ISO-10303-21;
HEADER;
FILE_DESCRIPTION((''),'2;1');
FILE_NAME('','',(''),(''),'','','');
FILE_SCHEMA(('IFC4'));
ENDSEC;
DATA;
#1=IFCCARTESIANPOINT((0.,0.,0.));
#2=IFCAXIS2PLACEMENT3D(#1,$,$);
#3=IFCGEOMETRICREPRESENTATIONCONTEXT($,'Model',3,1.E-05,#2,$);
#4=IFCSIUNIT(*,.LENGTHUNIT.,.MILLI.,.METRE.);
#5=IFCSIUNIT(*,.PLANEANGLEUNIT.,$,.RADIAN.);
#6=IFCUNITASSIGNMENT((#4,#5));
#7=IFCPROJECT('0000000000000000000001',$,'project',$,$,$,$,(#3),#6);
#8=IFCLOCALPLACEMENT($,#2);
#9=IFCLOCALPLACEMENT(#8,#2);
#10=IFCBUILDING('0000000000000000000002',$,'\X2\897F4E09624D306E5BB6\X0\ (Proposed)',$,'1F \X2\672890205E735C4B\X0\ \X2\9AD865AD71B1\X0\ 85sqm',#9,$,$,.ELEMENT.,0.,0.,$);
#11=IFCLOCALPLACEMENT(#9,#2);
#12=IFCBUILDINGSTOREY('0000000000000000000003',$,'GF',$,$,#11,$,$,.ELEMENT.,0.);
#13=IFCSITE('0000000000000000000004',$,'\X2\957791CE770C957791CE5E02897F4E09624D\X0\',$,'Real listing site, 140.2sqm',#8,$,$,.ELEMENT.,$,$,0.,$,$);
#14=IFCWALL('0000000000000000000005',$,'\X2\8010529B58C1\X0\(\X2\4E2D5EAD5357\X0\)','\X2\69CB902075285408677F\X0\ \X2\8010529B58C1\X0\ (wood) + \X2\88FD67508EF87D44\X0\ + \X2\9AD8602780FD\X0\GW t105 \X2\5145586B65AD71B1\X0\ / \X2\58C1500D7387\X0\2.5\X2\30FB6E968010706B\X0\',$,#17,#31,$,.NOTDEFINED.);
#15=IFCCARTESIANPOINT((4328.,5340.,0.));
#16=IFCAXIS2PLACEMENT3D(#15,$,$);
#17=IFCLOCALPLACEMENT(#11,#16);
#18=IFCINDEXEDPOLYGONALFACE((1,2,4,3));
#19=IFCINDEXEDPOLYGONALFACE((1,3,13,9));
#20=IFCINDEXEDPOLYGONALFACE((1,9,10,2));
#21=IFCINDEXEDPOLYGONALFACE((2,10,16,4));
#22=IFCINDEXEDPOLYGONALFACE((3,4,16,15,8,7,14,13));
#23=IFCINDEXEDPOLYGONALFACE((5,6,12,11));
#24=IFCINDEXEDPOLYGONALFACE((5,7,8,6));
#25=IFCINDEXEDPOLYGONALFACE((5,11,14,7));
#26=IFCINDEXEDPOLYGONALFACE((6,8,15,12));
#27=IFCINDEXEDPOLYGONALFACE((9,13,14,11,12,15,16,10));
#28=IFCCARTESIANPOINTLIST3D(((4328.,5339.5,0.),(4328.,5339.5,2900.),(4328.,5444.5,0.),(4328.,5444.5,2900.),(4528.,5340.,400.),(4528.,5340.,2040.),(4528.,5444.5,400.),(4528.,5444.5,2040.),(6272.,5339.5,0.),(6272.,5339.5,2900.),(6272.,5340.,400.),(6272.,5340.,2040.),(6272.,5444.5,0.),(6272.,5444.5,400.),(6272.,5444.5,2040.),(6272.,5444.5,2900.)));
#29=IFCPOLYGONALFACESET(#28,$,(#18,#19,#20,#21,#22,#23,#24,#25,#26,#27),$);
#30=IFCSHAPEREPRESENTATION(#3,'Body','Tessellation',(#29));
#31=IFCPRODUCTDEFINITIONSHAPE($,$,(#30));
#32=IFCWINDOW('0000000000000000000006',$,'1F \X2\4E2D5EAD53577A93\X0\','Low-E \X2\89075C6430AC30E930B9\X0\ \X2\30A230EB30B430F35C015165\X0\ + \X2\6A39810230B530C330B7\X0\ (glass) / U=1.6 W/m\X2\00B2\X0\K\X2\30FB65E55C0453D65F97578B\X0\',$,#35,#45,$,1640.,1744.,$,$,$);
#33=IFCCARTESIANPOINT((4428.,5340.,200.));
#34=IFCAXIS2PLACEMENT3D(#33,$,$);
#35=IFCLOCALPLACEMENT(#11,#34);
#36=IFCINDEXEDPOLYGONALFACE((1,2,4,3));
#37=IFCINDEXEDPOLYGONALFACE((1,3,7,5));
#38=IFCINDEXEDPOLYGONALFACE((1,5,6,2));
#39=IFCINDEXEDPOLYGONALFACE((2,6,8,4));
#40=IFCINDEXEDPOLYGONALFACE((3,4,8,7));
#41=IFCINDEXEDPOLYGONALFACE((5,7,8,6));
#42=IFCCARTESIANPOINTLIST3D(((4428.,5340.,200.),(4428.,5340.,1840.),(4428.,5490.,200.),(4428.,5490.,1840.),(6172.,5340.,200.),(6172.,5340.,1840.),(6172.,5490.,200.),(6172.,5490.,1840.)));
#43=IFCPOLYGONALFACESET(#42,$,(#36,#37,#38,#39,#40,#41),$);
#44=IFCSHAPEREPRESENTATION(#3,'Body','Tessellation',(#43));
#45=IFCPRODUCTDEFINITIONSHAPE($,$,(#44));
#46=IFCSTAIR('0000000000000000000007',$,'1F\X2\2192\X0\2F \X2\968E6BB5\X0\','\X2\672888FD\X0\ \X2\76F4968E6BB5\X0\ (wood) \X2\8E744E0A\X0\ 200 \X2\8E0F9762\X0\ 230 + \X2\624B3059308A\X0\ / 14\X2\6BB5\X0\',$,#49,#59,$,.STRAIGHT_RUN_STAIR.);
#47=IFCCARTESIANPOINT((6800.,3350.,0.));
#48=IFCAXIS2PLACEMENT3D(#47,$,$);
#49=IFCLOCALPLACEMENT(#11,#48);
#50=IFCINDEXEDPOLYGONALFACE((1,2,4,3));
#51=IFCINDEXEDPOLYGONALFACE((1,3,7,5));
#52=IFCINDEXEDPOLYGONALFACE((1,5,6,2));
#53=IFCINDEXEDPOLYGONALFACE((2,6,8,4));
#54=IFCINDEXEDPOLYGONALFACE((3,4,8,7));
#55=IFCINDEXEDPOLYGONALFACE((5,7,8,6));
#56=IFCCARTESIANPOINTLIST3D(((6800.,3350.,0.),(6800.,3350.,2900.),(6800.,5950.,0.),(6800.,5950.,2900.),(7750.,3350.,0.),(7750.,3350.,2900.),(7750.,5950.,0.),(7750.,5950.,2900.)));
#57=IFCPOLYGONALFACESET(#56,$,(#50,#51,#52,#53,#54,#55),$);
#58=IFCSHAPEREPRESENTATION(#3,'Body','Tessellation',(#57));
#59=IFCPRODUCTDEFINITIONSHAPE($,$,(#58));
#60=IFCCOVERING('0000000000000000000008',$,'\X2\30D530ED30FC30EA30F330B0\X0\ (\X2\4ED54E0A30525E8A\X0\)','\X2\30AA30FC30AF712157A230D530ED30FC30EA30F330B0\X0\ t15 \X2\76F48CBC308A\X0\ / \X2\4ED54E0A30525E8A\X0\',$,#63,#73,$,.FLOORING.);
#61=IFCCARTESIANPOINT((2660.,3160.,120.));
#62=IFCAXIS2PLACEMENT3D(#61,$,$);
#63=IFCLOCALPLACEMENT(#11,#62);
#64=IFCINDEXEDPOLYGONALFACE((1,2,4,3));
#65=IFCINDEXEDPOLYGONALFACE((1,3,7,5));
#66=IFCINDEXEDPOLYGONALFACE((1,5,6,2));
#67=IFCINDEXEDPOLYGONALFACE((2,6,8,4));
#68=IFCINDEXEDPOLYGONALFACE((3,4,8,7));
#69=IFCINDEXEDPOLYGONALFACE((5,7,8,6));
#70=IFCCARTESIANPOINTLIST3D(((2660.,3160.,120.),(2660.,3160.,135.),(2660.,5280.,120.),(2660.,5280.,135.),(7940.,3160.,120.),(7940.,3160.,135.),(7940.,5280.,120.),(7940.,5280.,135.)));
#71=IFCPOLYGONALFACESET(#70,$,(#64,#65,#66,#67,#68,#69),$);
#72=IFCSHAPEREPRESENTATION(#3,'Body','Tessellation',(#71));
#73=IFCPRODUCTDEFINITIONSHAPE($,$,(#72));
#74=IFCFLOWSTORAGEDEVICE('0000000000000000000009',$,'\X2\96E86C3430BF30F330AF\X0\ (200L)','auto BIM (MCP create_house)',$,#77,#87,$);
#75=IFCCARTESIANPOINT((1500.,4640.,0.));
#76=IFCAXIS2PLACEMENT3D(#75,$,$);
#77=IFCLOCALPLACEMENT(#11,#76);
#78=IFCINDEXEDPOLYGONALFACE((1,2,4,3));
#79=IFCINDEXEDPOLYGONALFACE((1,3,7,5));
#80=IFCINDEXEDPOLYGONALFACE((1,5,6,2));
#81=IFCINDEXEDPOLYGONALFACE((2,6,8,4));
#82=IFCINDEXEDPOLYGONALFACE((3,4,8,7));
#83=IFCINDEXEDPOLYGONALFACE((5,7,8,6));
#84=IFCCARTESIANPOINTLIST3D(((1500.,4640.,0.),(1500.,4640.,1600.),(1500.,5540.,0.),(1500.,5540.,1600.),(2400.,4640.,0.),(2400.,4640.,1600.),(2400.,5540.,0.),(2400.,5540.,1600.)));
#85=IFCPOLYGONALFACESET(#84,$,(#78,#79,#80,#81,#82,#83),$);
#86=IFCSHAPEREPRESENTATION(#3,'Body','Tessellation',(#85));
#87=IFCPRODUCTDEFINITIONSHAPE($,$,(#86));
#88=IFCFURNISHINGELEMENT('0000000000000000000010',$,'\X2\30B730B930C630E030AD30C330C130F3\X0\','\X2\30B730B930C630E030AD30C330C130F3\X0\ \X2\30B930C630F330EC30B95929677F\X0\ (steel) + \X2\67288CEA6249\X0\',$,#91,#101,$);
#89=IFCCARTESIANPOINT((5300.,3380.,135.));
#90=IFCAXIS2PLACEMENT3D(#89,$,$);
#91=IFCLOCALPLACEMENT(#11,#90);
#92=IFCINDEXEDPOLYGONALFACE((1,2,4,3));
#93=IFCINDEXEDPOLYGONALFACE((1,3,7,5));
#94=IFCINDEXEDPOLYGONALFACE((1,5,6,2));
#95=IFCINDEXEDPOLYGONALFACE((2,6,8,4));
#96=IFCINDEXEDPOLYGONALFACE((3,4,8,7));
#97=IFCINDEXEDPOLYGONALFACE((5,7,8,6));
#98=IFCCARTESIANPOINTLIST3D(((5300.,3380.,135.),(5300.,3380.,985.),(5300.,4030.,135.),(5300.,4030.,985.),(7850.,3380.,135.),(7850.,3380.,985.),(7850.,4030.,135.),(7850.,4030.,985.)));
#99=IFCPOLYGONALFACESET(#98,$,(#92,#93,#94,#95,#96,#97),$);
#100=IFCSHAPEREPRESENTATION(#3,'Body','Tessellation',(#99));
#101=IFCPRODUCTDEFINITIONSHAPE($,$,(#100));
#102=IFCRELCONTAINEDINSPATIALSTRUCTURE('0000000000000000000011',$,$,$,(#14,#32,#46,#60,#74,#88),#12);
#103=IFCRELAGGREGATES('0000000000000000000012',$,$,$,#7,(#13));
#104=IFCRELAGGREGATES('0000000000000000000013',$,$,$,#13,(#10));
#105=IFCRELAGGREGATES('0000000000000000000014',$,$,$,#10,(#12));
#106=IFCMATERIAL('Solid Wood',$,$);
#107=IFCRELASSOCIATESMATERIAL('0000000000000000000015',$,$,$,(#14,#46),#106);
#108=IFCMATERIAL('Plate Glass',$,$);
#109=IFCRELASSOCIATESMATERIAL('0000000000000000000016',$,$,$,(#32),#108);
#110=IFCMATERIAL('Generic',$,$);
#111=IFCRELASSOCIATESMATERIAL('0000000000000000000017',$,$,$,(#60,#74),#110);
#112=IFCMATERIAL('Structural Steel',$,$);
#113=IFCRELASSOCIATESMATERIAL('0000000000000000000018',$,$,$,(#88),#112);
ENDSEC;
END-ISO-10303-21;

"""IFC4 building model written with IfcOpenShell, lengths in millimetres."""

from ifc_helpers import new_model, si_unit, frame, frame_2d, origin, place, context, project, spatial, rectangle, extrude, material, element, fill, save


model = new_model("IFC4")

# Units and contexts
model_context = context("Model", 3, precision=1e-05, world=origin())
ifc_project = project(units=[si_unit("LENGTHUNIT", "METRE", prefix="MILLI"), si_unit("PLANEANGLEUNIT", "RADIAN")], contexts=[model_context])

# Site, building, storey
site_placement = place(None, origin())
site = spatial("IfcSite", under=ifc_project, at=site_placement, Name="長野県長野市西三才", ObjectType="Real listing site, 140.2sqm", CompositionType="ELEMENT", RefElevation=0.0)
building_placement = place(site_placement, origin())
building = spatial("IfcBuilding", under=site, at=building_placement, Name="西三才の家 (Proposed)", ObjectType="1F 木造平屋 高断熱 85sqm", CompositionType="ELEMENT", ElevationOfRefHeight=0.0, ElevationOfTerrain=0.0)
storey_placement = place(building_placement, origin())
storey = spatial("IfcBuildingStorey", under=building, at=storey_placement, Name="GF", CompositionType="ELEMENT", Elevation=0.0)

# Shared definitions
ifc_material_1 = material(Name="Solid Wood")
ifc_material_2 = material(Name="Generic")

# Shared definitions
ifc_material_3 = material(Name="Plate Glass")

# Wall, opening, window
wall_1_placement = place(storey_placement, frame((4328.0, 5340.0, 0.0)))
wall_1 = element("IfcWall", 1, at=wall_1_placement, inside=storey, material=ifc_material_1, Name="耐力壁(中庭南)", Description="構造用合板 耐力壁 (wood) + 製材軸組 + 高性能GW t105 充填断熱 / 壁倍率2.5・準耐火", PredefinedType="NOTDEFINED", context=model_context, shape_type="SweptSolid", body=[
    extrude(rectangle(XDim=1944.0, YDim=105.0, at=frame_2d((972.0, 52.0))), frame((4328.0, 5340.0, 0.0)), (0.0, 0.0, 1.0), 2900.0),
])
opening_1_placement = place(storey_placement, frame((4428.0, 5340.0, 200.0)))
opening_1 = element("IfcOpeningElement", 2, at=opening_1_placement, cuts=wall_1, PredefinedType="NOTDEFINED", context=model_context, shape_type="SweptSolid", body=[
    extrude(rectangle(XDim=1744.0, YDim=150.0, at=frame_2d((872.0, 75.0))), frame((4428.0, 5340.0, 200.0)), (0.0, 0.0, 1.0), 1640.0),
])
window_1_placement = place(storey_placement, frame((4428.0, 5340.0, 200.0)))
window_1 = element("IfcWindow", 3, at=window_1_placement, inside=storey, material=ifc_material_3, Name="1F 中庭南窓", Description="Low-E 複層ガラス アルゴン封入 + 樹脂サッシ (glass) / U=1.6 W/m²K・日射取得型", OverallHeight=1640.0, OverallWidth=1744.0, context=model_context, shape_type="SweptSolid", body=[
    extrude(rectangle(XDim=1744.0, YDim=150.0, at=frame_2d((872.0, 75.0))), frame((4428.0, 5340.0, 200.0)), (0.0, 0.0, 1.0), 1640.0),
])
fill(opening_1, window_1)

# Stair
stair_placement = place(storey_placement, frame((6800.0, 3350.0, 0.0)))
element("IfcStair", 4, at=stair_placement, inside=storey, material=ifc_material_1, Name="1F→2F 階段", Description="木製 直階段 (wood) 蹴上 200 踏面 230 + 手すり / 14段", PredefinedType="STRAIGHT_RUN_STAIR", context=model_context, shape_type="SweptSolid", body=[
    extrude(rectangle(XDim=950.0, YDim=2600.0, at=frame_2d((475.0, 1300.0))), frame((6800.0, 3350.0, 0.0)), (0.0, 0.0, 1.0), 2900.0),
])

# Covering
covering_placement = place(storey_placement, frame((2660.0, 3160.0, 120.0)))
element("IfcCovering", 5, at=covering_placement, inside=storey, material=ifc_material_2, Name="フローリング (仕上げ床)", Description="オーク無垢フローリング t15 直貼り / 仕上げ床", PredefinedType="FLOORING", context=model_context, shape_type="SweptSolid", body=[
    extrude(rectangle(XDim=5280.0, YDim=2120.0, at=frame_2d((2640.0, 1060.0))), frame((2660.0, 3160.0, 120.0)), (0.0, 0.0, 1.0), 15.0),
])

# Flow storage device
flow_storage_device_placement = place(storey_placement, frame((1500.0, 4640.0, 0.0)))
element("IfcFlowStorageDevice", 6, at=flow_storage_device_placement, inside=storey, material=ifc_material_2, Name="雨水タンク (200L)", Description="auto BIM (MCP create_house)", context=model_context, shape_type="SweptSolid", body=[
    extrude(rectangle(XDim=900.0, YDim=900.0, at=frame_2d((450.0, 450.0))), frame((1500.0, 4640.0, 0.0)), (0.0, 0.0, 1.0), 1600.0),
])

# Furnishing element
ifc_material_4 = material(Name="Structural Steel")
furnishing_placement = place(storey_placement, frame((5300.0, 3380.0, 135.0)))
element("IfcFurnishingElement", 7, at=furnishing_placement, inside=storey, material=ifc_material_4, Name="システムキッチン", Description="システムキッチン ステンレス天板 (steel) + 木質扉", context=model_context, shape_type="SweptSolid", body=[
    extrude(rectangle(XDim=2550.0, YDim=650.0, at=frame_2d((1275.0, 325.0))), frame((5300.0, 3380.0, 135.0)), (0.0, 0.0, 1.0), 850.0),
])

save(model, "model.ifc")
